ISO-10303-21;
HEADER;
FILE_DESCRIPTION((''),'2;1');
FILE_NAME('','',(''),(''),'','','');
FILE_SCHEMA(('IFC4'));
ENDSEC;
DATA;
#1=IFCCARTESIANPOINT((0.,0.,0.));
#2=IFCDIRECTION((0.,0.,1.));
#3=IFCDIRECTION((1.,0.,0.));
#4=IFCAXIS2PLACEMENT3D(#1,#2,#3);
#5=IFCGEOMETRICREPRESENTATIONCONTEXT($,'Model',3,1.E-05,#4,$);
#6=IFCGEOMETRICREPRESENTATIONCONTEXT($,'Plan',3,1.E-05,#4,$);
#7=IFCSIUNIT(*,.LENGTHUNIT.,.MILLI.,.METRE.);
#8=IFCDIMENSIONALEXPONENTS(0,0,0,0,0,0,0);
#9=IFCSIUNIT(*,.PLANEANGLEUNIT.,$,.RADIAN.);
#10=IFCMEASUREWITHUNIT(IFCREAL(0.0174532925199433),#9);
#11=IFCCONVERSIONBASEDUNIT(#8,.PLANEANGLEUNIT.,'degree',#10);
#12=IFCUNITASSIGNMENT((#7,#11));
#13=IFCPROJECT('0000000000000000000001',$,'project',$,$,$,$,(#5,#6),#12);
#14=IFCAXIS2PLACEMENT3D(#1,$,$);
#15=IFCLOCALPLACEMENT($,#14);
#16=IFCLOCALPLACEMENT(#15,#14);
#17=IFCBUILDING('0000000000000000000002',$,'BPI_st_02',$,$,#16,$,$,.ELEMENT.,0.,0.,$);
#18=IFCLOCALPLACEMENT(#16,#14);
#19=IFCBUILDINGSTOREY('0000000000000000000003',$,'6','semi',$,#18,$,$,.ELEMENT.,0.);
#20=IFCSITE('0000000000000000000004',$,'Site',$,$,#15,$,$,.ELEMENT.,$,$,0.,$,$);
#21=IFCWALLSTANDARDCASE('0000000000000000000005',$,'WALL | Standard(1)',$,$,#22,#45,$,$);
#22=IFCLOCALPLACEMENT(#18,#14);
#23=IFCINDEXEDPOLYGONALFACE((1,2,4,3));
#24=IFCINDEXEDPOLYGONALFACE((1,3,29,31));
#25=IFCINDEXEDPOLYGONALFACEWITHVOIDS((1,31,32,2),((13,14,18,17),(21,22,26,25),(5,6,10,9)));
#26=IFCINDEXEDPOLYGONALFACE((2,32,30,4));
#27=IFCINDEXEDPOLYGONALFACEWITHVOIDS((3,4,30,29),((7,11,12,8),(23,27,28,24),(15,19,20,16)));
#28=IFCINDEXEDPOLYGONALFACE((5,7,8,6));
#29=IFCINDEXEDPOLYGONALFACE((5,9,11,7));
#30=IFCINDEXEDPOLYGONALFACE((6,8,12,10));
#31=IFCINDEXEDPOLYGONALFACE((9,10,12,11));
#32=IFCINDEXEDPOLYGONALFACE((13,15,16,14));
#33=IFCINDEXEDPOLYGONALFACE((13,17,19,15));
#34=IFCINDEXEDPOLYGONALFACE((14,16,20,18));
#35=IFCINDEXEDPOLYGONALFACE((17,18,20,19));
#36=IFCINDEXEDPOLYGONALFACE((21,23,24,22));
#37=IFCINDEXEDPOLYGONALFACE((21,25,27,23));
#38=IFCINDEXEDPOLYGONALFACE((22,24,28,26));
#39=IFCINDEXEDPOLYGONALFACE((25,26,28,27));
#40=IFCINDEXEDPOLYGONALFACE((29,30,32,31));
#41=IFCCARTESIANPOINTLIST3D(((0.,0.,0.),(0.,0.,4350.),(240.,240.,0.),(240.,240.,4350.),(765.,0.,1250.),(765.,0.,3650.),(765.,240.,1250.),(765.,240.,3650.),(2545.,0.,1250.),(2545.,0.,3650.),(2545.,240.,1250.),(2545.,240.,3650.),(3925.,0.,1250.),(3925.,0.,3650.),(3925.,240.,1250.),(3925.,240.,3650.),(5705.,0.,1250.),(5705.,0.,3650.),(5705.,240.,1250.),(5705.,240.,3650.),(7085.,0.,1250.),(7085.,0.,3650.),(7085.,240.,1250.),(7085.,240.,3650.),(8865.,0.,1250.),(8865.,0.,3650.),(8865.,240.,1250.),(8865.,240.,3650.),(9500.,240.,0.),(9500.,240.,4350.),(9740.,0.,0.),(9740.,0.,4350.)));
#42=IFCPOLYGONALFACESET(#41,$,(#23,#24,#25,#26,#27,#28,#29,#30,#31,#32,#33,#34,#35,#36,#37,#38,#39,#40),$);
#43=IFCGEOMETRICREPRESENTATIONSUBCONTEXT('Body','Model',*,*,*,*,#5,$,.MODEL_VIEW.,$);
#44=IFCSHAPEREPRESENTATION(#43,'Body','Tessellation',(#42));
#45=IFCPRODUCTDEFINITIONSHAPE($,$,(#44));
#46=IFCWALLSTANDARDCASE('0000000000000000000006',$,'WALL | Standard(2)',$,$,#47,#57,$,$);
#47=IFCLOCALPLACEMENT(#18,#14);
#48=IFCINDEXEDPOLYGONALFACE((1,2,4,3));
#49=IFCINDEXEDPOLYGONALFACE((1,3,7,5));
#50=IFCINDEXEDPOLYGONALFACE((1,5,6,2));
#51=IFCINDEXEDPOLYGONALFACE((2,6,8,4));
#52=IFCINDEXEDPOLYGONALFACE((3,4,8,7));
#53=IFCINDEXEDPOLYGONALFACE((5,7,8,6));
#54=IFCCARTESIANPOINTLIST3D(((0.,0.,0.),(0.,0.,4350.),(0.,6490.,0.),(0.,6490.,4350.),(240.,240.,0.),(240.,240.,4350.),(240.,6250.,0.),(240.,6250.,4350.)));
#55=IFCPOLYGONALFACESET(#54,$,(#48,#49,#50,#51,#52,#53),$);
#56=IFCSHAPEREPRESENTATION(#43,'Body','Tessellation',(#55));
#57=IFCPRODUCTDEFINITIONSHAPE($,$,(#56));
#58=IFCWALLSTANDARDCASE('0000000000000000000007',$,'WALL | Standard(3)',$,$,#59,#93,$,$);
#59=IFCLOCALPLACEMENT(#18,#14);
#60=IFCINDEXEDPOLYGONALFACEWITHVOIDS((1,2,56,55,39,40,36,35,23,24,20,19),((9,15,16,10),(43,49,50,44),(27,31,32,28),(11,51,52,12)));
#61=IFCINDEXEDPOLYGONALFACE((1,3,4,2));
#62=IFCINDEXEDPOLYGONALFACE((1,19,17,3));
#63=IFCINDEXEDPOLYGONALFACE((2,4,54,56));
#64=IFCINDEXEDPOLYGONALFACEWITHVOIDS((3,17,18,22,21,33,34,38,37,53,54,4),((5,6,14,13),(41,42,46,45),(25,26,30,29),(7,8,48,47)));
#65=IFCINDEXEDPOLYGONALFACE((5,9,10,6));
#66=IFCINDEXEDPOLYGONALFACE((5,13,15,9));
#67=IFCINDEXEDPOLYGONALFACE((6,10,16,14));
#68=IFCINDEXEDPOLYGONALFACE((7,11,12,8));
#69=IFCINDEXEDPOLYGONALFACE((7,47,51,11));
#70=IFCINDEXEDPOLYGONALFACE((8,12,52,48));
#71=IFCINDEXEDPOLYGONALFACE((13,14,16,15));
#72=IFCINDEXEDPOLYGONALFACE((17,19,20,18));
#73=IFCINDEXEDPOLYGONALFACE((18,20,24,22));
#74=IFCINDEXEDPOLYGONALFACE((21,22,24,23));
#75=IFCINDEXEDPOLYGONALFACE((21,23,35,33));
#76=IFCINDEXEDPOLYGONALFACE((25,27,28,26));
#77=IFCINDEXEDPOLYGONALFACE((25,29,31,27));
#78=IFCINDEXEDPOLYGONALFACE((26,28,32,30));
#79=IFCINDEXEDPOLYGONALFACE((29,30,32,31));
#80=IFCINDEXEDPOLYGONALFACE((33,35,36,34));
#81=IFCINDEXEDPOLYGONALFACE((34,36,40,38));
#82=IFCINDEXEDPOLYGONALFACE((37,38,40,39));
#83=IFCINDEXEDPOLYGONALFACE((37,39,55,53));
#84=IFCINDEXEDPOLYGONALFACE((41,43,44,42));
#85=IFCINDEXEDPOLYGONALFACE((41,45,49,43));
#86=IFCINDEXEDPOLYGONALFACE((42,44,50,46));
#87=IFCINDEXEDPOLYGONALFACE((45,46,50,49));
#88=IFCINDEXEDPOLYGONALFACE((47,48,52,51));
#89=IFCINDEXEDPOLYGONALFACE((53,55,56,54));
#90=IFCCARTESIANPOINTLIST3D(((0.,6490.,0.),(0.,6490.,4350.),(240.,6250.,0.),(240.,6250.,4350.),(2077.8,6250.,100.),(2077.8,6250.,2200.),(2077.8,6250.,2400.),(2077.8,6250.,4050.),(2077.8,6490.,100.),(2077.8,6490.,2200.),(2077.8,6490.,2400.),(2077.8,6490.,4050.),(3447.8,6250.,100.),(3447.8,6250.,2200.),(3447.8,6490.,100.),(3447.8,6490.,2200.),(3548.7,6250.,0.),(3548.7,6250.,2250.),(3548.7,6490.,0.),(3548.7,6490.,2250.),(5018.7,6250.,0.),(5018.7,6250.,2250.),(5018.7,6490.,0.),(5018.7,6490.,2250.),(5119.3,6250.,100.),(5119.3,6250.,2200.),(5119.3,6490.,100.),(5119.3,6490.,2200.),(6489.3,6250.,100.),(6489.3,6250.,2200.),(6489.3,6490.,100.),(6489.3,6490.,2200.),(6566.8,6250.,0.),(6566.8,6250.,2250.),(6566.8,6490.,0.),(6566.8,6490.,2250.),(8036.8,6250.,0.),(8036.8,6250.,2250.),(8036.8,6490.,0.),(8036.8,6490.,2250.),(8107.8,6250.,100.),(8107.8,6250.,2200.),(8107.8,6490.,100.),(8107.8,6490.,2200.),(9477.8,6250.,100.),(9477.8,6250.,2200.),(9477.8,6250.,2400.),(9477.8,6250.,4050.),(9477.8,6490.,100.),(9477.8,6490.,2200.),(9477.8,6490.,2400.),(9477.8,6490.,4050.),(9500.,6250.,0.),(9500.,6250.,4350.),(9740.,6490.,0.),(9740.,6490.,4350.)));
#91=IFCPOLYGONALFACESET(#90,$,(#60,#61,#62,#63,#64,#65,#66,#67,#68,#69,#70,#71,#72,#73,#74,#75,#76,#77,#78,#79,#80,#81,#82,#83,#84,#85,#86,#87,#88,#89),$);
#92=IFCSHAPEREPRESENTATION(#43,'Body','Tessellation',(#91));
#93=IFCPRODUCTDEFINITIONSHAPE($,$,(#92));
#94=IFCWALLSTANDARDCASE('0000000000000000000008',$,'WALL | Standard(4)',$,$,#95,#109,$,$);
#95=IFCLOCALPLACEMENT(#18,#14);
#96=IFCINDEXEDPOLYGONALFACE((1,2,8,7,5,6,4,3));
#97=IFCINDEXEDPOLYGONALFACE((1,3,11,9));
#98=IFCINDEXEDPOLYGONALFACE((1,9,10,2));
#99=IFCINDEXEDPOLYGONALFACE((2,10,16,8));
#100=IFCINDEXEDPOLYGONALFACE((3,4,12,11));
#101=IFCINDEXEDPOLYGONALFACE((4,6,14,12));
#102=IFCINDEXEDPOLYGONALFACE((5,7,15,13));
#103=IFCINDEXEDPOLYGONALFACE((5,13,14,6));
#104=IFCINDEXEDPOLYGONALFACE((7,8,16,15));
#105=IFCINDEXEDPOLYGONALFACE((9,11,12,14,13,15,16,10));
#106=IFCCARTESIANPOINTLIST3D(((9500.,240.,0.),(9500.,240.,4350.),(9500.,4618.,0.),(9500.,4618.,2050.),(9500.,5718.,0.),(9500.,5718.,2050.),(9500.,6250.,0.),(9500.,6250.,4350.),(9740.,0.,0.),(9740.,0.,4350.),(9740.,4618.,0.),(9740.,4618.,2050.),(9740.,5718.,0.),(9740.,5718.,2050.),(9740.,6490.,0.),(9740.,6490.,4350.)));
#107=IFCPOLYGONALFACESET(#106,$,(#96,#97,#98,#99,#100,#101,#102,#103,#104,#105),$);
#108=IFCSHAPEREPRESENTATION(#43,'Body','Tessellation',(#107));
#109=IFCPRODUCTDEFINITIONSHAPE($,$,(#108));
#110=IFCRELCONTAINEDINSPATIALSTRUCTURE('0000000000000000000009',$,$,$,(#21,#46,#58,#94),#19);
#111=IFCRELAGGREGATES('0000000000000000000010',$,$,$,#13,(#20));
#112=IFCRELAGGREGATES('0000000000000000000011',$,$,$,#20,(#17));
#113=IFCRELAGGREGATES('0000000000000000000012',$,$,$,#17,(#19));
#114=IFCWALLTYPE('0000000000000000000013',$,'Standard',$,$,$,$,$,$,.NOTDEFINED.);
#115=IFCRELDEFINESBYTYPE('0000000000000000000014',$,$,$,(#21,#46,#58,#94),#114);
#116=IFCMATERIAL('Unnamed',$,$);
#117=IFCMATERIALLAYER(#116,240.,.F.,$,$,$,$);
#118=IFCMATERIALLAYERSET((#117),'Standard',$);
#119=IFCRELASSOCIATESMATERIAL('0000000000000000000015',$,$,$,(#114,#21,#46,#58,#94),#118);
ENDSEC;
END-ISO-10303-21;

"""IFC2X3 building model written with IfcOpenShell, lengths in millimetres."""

from ifc_helpers import new_model, entity, si_unit, converted_unit, frame, frame_2d, origin, origin_with_axes, origin_2d_with_axis, place, context, subcontext, project, spatial, polyline, segment, composite_curve, rectangle, outline, extrude, material, layer, layer_set, layer_usage, type_object, element, save


model = new_model("IFC2X3")

# Units and contexts
model_context = context("Model", 3, precision=1e-05, world=origin_with_axes())
plan_context = context("Plan", 3, precision=1e-05, world=origin_with_axes())
body_context = subcontext(model_context, "Body", "Model", "MODEL_VIEW")
ifc_project = project(units=[si_unit("LENGTHUNIT", "METRE", prefix="MILLI"), converted_unit("PLANEANGLEUNIT", "degree", entity("IfcReal", 0.0174532925199433), si_unit("PLANEANGLEUNIT", "RADIAN"), dimensions=[0, 0, 0, 0, 0, 0, 0])], contexts=[model_context, plan_context])

# Site, building, storey
site_placement = place(None, origin())
site = spatial("IfcSite", under=ifc_project, at=site_placement, Name="Site", CompositionType="ELEMENT", RefElevation=0.0)
building_placement = place(site_placement, origin())
building = spatial("IfcBuilding", under=site, at=building_placement, Name="BPI_st_02", CompositionType="ELEMENT", ElevationOfRefHeight=0.0, ElevationOfTerrain=0.0)
storey_placement = place(building_placement, origin())
storey = spatial("IfcBuildingStorey", under=building, at=storey_placement, Name="6", Description="semi", CompositionType="ELEMENT", Elevation=0.0)

# Shared definitions
ifc_material = material(Name="Unnamed")

# Wall, openings
ifc_layer_1 = layer(ifc_material, 240.0, ventilated=False)
ifc_layer_set_1 = layer_set([ifc_layer_1], Name="Standard")
ifc_layer_usage_1 = layer_usage(ifc_layer_set_1, "AXIS2", "POSITIVE", -120.0)
wall_type = type_object("IfcWallType", Name="Standard", PredefinedType="NOTDEFINED", material=ifc_layer_set_1)
wall_1_placement = place(storey_placement, frame((9620.0, 120.0, 0.0), z_axis=(0.0, 0.0, 1.0), x_axis=(-1.0, 0.0, 0.0)))
wall_1 = element("IfcWallStandardCase", 1, at=wall_1_placement, inside=storey, type_object=wall_type, material=ifc_layer_usage_1, Name="WALL | Standard(1)", context=body_context, shape_type="SweptSolid", body=[
    extrude(outline(composite_curve([segment(polyline([(-120.0, 120.0), (120.0, -120.0)]), True, "CONTINUOUS"), segment(polyline([(120.0, -120.0), (9380.0, -120.0)]), True, "CONTINUOUS"), segment(polyline([(9380.0, -120.0), (9620.0, 120.0)]), True, "CONTINUOUS"), segment(polyline([(9620.0, 120.0), (-120.0, 120.0)]), True, "CONTINUOUS")], self_intersect=False)), origin(), (0.0, 0.0, 1.0), 4350.0),
])
opening_1_placement = place(wall_1_placement, frame((7075.1, 0.0, 1250.0)))
element("IfcOpeningElement", 2, at=opening_1_placement, cuts=wall_1, context=body_context, shape_type="SweptSolid", body=[
    extrude(rectangle(XDim=1780.0, YDim=2400.0, at=origin_2d_with_axis()), frame((890.0, 120.0, 1200.0), z_axis=(0.0, -1.0, 0.0), x_axis=(1.0, 0.0, 0.0)), (0.0, 0.0, 1.0), 240.0),
])
opening_2_placement = place(wall_1_placement, frame((3915.1, 0.0, 1250.0)))
element("IfcOpeningElement", 3, at=opening_2_placement, cuts=wall_1, context=body_context, shape_type="SweptSolid", body=[
    extrude(rectangle(XDim=1780.0, YDim=2400.0, at=origin_2d_with_axis()), frame((890.0, 120.0, 1200.0), z_axis=(0.0, -1.0, 0.0), x_axis=(1.0, 0.0, 0.0)), (0.0, 0.0, 1.0), 240.0),
])
opening_3_placement = place(wall_1_placement, frame((755.1, 0.0, 1250.0)))
element("IfcOpeningElement", 4, at=opening_3_placement, cuts=wall_1, context=body_context, shape_type="SweptSolid", body=[
    extrude(rectangle(XDim=1780.0, YDim=2400.0, at=origin_2d_with_axis()), frame((890.0, 120.0, 1200.0), z_axis=(0.0, -1.0, 0.0), x_axis=(1.0, 0.0, 0.0)), (0.0, 0.0, 1.0), 240.0),
])

# Wall
ifc_layer_usage_2 = layer_usage(ifc_layer_set_1, "AXIS2", "POSITIVE", -120.0)
wall_2_placement = place(storey_placement, frame((120.0, 120.0, 0.0), z_axis=(0.0, 0.0, 1.0), x_axis=(0.0, 1.0, 0.0)))
element("IfcWallStandardCase", 5, at=wall_2_placement, inside=storey, type_object=wall_type, material=ifc_layer_usage_2, Name="WALL | Standard(2)", context=body_context, shape_type="SweptSolid", body=[
    extrude(outline(composite_curve([segment(polyline([(-120.0, 120.0), (120.0, -120.0)]), True, "CONTINUOUS"), segment(polyline([(120.0, -120.0), (6130.0, -120.0)]), True, "CONTINUOUS"), segment(polyline([(6130.0, -120.0), (6370.0, 120.0)]), True, "CONTINUOUS"), segment(polyline([(6370.0, 120.0), (-120.0, 120.0)]), True, "CONTINUOUS")], self_intersect=False)), origin(), (0.0, 0.0, 1.0), 4350.0),
])

# Wall, openings
ifc_layer_usage_3 = layer_usage(ifc_layer_set_1, "AXIS2", "POSITIVE", -120.0)
wall_3_placement = place(storey_placement, frame((120.0, 6370.0, 0.0)))
wall_3 = element("IfcWallStandardCase", 6, at=wall_3_placement, inside=storey, type_object=wall_type, material=ifc_layer_usage_3, Name="WALL | Standard(3)", context=body_context, shape_type="SweptSolid", body=[
    extrude(outline(composite_curve([segment(polyline([(-120.0, 120.0), (120.0, -120.0)]), True, "CONTINUOUS"), segment(polyline([(120.0, -120.0), (9380.0, -120.0)]), True, "CONTINUOUS"), segment(polyline([(9380.0, -120.0), (9620.0, 120.0)]), True, "CONTINUOUS"), segment(polyline([(9620.0, 120.0), (-120.0, 120.0)]), True, "CONTINUOUS")], self_intersect=False)), origin(), (0.0, 0.0, 1.0), 4350.0),
])
opening_4_placement = place(wall_3_placement, frame((1957.8, 0.0, 2400.0)))
element("IfcOpeningElement", 7, at=opening_4_placement, cuts=wall_3, context=body_context, shape_type="SweptSolid", body=[
    extrude(rectangle(XDim=7400.0, YDim=1650.0, at=origin_2d_with_axis()), frame((3700.0, 120.0, 825.0), z_axis=(0.0, -1.0, 0.0), x_axis=(1.0, 0.0, 0.0)), (0.0, 0.0, 1.0), 240.0),
])
opening_5_placement = place(wall_3_placement, frame((1957.8, 0.0, 100.0)))
element("IfcOpeningElement", 8, at=opening_5_placement, cuts=wall_3, context=body_context, shape_type="SweptSolid", body=[
    extrude(rectangle(XDim=1370.0, YDim=2100.0, at=origin_2d_with_axis()), frame((685.0, 120.0, 1050.0), z_axis=(0.0, -1.0, 0.0), x_axis=(1.0, 0.0, 0.0)), (0.0, 0.0, 1.0), 240.0),
])
opening_6_placement = place(wall_3_placement, frame((4999.3, 0.0, 100.0)))
element("IfcOpeningElement", 9, at=opening_6_placement, cuts=wall_3, context=body_context, shape_type="SweptSolid", body=[
    extrude(rectangle(XDim=1370.0, YDim=2100.0, at=origin_2d_with_axis()), frame((685.0, 120.0, 1050.0), z_axis=(0.0, -1.0, 0.0), x_axis=(1.0, 0.0, 0.0)), (0.0, 0.0, 1.0), 240.0),
])
opening_7_placement = place(wall_3_placement, frame((7987.8, 0.0, 100.0)))
element("IfcOpeningElement", 10, at=opening_7_placement, cuts=wall_3, context=body_context, shape_type="SweptSolid", body=[
    extrude(rectangle(XDim=1370.0, YDim=2100.0, at=origin_2d_with_axis()), frame((685.0, 120.0, 1050.0), z_axis=(0.0, -1.0, 0.0), x_axis=(1.0, 0.0, 0.0)), (0.0, 0.0, 1.0), 240.0),
])
opening_8_placement = place(wall_3_placement, frame((3428.7, 0.0, 0.0)))
element("IfcOpeningElement", 11, at=opening_8_placement, cuts=wall_3, context=body_context, shape_type="SweptSolid", body=[
    extrude(rectangle(XDim=2250.0, YDim=1470.0, at=frame_2d((0.0, 0.0), x_axis=(0.0, 1.0))), frame((735.0, 120.0, 1125.0), z_axis=(0.0, -1.0, 0.0), x_axis=(1.0, 0.0, 0.0)), (0.0, 0.0, 1.0), 240.0),
])
opening_9_placement = place(wall_3_placement, frame((6446.8, 0.0, 0.0)))
element("IfcOpeningElement", 12, at=opening_9_placement, cuts=wall_3, context=body_context, shape_type="SweptSolid", body=[
    extrude(rectangle(XDim=2250.0, YDim=1470.0, at=frame_2d((0.0, 0.0), x_axis=(0.0, 1.0))), frame((735.0, 120.0, 1125.0), z_axis=(0.0, -1.0, 0.0), x_axis=(1.0, 0.0, 0.0)), (0.0, 0.0, 1.0), 240.0),
])

# Wall, opening
ifc_layer_usage_4 = layer_usage(ifc_layer_set_1, "AXIS2", "POSITIVE", -120.0)
wall_4_placement = place(storey_placement, frame((9620.0, 6370.0, 0.0), z_axis=(0.0, 0.0, 1.0), x_axis=(0.0, -1.0, 0.0)))
wall_4 = element("IfcWallStandardCase", 13, at=wall_4_placement, inside=storey, type_object=wall_type, material=ifc_layer_usage_4, Name="WALL | Standard(4)", context=body_context, shape_type="SweptSolid", body=[
    extrude(outline(composite_curve([segment(polyline([(-120.0, 120.0), (120.0, -120.0)]), True, "CONTINUOUS"), segment(polyline([(120.0, -120.0), (6130.0, -120.0)]), True, "CONTINUOUS"), segment(polyline([(6130.0, -120.0), (6370.0, 120.0)]), True, "CONTINUOUS"), segment(polyline([(6370.0, 120.0), (-120.0, 120.0)]), True, "CONTINUOUS")], self_intersect=False)), origin(), (0.0, 0.0, 1.0), 4350.0),
])
opening_10_placement = place(wall_4_placement, frame((652.0, 0.0, 0.0)))
element("IfcOpeningElement", 14, at=opening_10_placement, cuts=wall_4, context=body_context, shape_type="SweptSolid", body=[
    extrude(rectangle(XDim=1100.0, YDim=2050.0, at=origin_2d_with_axis()), frame((550.0, 120.0, 1025.0), z_axis=(0.0, -1.0, 0.0), x_axis=(1.0, 0.0, 0.0)), (0.0, 0.0, 1.0), 240.0),
])

save(model, "model.ifc")
